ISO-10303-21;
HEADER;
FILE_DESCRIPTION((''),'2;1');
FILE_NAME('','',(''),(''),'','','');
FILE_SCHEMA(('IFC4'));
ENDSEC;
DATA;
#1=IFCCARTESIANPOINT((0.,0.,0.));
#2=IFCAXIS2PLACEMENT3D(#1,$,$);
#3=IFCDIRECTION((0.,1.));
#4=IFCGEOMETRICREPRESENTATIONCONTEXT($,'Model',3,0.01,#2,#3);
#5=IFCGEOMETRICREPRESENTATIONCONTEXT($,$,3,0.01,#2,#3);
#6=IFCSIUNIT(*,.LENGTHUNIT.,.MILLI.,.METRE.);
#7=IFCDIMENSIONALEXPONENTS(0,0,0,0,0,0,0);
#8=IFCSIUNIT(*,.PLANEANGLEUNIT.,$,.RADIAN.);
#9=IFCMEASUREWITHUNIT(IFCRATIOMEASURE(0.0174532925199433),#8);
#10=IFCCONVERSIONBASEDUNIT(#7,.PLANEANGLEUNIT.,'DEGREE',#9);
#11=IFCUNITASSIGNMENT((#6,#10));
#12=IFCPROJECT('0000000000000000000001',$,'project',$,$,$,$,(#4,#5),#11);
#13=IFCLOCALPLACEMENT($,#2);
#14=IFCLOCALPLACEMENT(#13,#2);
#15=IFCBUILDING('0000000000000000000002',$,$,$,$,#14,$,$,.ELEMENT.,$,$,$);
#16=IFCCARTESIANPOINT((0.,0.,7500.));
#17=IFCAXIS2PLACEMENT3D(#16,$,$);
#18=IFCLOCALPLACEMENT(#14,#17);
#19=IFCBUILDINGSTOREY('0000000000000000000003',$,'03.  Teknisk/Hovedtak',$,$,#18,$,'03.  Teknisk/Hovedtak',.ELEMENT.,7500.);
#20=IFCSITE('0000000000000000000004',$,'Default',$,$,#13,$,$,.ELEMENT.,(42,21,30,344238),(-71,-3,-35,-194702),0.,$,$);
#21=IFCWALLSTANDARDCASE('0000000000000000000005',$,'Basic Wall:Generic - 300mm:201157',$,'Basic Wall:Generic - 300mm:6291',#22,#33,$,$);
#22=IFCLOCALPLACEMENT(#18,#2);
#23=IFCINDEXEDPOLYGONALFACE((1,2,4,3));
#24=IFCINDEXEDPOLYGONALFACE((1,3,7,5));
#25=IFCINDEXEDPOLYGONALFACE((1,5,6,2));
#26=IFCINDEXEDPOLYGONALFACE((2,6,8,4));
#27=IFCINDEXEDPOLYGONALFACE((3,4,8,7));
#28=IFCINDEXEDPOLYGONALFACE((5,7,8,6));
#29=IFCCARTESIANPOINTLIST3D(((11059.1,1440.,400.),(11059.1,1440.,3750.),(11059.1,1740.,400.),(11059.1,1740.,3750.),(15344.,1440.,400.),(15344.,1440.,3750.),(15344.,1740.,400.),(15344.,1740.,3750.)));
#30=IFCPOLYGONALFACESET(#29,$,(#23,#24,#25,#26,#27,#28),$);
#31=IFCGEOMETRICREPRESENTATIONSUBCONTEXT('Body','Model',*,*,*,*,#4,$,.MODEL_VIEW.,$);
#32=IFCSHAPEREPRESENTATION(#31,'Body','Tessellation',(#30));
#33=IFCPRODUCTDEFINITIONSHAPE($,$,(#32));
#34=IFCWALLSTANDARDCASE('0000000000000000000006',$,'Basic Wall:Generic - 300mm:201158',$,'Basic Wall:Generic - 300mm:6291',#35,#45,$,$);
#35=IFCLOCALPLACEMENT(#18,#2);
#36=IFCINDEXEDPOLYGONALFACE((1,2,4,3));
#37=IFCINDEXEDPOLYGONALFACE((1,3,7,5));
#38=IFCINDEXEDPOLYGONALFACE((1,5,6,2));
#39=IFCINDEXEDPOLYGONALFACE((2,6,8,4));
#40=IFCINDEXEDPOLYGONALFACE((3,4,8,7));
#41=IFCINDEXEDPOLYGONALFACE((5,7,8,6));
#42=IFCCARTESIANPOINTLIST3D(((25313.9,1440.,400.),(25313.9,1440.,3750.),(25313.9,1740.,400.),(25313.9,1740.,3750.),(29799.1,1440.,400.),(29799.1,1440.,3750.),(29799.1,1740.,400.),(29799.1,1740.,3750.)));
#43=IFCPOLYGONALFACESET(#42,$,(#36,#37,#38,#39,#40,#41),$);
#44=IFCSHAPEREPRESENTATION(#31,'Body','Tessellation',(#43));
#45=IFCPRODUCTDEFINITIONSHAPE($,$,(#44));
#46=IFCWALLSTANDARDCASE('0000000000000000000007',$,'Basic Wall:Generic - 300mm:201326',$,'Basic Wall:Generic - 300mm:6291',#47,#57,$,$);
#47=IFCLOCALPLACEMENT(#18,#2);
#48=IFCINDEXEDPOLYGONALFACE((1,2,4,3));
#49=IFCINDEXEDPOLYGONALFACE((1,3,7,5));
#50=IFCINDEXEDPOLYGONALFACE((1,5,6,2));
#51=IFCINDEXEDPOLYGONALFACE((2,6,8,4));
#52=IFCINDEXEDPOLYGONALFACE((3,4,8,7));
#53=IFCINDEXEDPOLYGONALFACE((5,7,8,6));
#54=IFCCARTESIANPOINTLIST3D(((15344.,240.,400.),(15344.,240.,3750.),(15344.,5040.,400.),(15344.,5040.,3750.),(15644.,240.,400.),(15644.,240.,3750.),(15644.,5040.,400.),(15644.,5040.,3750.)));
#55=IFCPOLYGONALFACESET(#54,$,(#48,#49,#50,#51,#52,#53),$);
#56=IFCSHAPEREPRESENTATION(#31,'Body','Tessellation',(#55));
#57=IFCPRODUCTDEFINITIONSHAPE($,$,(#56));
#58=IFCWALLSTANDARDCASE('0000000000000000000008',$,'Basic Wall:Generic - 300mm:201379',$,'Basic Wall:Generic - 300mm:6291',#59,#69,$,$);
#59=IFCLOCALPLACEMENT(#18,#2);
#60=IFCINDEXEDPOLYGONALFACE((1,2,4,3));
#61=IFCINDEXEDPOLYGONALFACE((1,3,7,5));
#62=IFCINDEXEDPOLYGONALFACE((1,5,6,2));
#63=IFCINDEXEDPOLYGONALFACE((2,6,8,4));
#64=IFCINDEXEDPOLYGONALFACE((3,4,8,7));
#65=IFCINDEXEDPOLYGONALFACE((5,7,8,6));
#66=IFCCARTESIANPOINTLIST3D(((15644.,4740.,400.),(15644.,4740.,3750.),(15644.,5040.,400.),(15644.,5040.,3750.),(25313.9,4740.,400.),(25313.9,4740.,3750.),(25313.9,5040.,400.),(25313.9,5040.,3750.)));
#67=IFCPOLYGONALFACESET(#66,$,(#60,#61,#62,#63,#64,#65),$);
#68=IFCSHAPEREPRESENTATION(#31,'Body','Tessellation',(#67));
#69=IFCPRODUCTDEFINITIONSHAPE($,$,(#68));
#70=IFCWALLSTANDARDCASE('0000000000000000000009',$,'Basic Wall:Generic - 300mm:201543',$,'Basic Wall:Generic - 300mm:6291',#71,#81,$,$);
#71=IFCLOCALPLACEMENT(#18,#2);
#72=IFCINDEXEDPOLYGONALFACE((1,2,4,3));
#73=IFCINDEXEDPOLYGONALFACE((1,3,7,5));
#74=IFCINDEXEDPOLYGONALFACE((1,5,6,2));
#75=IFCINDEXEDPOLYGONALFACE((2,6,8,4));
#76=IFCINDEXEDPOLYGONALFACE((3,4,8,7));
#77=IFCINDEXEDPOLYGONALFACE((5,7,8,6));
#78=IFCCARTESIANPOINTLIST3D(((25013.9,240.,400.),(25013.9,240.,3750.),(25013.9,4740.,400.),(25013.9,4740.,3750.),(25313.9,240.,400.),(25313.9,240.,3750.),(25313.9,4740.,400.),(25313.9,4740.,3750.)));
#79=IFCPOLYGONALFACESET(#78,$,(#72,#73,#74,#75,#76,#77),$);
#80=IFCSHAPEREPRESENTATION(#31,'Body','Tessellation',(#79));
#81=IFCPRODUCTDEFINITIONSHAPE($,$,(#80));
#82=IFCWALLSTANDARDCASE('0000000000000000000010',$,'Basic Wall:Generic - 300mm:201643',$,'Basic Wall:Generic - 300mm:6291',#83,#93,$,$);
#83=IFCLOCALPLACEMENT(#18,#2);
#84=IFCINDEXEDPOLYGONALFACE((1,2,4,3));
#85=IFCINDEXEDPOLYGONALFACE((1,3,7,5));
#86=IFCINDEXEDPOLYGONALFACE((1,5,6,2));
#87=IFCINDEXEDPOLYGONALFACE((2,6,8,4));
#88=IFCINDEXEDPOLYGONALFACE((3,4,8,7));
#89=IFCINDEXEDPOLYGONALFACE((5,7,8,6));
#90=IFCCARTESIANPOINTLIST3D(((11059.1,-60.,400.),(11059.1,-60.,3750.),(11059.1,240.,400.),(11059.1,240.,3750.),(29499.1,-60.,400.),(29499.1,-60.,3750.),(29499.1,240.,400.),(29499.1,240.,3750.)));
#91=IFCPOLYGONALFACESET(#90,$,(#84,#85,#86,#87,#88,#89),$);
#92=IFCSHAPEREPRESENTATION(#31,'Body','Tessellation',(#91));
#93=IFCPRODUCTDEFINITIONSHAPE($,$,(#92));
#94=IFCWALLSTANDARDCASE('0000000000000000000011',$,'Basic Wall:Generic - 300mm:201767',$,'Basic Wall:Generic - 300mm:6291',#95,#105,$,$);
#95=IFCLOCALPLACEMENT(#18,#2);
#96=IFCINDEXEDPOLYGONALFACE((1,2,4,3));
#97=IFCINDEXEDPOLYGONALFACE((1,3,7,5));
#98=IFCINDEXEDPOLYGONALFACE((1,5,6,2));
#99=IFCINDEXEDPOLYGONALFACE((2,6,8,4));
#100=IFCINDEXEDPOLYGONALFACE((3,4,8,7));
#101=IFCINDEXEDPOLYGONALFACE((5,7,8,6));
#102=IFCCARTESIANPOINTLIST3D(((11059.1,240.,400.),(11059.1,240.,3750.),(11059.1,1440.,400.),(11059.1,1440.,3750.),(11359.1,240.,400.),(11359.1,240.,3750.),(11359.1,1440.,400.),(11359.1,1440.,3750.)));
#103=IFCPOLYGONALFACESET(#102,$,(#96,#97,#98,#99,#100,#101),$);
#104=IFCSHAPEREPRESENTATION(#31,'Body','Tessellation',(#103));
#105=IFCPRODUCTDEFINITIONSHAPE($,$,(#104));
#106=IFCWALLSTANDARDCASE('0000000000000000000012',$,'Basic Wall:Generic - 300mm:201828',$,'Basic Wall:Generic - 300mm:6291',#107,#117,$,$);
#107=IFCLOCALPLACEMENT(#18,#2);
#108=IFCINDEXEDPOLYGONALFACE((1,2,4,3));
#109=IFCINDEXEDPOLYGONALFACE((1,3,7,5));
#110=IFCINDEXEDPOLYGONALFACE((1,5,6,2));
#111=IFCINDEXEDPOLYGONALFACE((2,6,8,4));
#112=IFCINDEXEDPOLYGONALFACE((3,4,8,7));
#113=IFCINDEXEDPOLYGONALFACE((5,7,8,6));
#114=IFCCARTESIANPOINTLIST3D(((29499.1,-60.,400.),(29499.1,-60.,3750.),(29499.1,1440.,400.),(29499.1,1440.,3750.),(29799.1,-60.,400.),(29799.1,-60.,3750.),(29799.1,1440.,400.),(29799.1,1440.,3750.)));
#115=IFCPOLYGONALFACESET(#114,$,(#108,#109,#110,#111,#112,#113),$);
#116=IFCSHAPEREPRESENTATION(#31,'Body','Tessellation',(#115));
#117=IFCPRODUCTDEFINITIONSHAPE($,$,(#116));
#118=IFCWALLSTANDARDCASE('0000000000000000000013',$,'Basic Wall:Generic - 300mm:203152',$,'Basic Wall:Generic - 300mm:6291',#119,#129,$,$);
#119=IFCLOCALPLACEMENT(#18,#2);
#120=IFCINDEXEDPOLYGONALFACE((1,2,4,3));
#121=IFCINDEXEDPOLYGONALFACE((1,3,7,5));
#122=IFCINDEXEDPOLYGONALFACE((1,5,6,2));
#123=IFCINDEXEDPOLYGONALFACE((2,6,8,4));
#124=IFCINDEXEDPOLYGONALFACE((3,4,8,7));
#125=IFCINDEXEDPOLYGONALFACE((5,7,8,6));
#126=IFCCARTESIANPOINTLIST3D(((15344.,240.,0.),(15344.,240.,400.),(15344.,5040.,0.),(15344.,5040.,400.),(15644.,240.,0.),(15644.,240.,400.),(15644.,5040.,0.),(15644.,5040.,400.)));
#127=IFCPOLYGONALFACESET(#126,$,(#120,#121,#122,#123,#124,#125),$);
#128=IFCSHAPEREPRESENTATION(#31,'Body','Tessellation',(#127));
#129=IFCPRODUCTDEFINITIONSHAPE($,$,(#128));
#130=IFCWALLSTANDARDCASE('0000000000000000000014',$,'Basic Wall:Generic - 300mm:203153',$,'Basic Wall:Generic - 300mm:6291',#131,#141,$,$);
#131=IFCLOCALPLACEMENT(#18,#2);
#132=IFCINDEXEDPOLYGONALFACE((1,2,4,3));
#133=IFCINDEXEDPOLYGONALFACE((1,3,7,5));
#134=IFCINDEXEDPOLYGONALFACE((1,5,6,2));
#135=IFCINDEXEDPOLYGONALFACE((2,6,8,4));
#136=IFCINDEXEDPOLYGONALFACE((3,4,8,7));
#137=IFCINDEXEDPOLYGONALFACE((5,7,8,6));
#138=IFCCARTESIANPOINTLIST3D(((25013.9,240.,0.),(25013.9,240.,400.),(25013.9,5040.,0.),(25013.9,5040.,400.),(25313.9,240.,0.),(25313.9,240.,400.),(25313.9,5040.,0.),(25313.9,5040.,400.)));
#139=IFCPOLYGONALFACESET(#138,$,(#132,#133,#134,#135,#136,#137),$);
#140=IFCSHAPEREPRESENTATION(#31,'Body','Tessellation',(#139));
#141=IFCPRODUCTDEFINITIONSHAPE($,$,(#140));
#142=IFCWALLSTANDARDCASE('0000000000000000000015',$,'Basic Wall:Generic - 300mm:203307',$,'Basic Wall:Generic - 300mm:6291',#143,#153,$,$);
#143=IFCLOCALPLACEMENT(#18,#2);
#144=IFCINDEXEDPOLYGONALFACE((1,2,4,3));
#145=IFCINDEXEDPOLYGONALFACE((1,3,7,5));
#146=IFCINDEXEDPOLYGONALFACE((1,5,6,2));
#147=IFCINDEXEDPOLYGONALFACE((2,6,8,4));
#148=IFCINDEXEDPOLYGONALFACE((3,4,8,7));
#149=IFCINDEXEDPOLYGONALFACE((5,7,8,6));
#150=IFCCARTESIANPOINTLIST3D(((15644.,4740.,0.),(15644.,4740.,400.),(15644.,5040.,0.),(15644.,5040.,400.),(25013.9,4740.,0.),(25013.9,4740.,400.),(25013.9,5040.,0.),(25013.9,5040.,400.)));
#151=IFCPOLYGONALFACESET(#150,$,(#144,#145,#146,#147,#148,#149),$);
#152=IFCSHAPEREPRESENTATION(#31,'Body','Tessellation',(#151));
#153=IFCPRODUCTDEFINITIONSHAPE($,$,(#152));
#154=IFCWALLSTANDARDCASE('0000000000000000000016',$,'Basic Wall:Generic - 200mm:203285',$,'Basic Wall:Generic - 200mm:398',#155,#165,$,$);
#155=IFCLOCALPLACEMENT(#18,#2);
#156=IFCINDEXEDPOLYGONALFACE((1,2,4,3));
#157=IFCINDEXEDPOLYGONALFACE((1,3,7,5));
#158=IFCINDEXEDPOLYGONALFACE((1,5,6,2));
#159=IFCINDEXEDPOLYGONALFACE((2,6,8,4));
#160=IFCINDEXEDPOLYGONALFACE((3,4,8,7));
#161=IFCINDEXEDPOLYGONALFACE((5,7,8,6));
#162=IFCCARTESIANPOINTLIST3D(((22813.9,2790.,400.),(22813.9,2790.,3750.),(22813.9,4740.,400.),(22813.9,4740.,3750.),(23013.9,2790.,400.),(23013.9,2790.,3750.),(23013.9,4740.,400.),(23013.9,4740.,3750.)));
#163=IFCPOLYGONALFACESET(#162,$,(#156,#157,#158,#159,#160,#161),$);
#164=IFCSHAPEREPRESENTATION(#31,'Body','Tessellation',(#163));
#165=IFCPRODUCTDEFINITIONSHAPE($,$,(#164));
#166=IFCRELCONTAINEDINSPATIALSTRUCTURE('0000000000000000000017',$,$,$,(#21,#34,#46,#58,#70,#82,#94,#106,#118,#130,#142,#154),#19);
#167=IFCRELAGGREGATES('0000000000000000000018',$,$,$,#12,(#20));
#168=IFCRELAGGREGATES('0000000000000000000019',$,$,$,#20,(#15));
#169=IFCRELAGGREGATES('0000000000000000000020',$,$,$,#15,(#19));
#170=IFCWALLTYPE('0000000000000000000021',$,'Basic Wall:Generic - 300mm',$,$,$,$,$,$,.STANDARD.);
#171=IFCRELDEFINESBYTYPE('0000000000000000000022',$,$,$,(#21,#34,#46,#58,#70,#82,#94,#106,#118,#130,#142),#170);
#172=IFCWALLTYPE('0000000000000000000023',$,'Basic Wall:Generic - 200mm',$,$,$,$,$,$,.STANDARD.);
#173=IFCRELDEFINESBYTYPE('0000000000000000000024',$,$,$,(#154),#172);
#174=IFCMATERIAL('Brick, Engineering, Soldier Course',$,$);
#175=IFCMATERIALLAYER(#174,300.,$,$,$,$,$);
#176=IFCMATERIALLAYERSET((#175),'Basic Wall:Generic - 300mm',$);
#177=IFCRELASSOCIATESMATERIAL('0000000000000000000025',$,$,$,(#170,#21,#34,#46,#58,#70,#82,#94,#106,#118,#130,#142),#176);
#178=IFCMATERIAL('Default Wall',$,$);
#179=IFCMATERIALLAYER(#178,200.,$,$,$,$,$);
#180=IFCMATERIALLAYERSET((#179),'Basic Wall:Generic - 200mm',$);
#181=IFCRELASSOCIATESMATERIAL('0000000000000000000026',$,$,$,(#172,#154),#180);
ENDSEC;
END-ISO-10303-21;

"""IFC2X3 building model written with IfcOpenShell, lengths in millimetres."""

from ifc_helpers import new_model, entity, si_unit, converted_unit, direction, frame, frame_2d, origin, place, context, subcontext, project, spatial, rectangle, extrude, clip, halfspace, material, layer, layer_set, layer_usage, type_object, element, save


model = new_model("IFC2X3")

# Units and contexts
model_context = context("Model", 3, precision=0.01, world=origin(), true_north=direction((0.0, 1.0)))
context_of_model = context(None, 3, precision=0.01, world=origin(), true_north=direction((0.0, 1.0)))
body_context = subcontext(model_context, "Body", "Model", "MODEL_VIEW")
ifc_project = project(units=[si_unit("LENGTHUNIT", "METRE", prefix="MILLI"), converted_unit("PLANEANGLEUNIT", "DEGREE", entity("IfcRatioMeasure", 0.0174532925199433), si_unit("PLANEANGLEUNIT", "RADIAN"), dimensions=[0, 0, 0, 0, 0, 0, 0])], contexts=[model_context, context_of_model])

# Site, building, storey
site_placement = place(None, origin())
site = spatial("IfcSite", under=ifc_project, at=site_placement, Name="Default", CompositionType="ELEMENT", RefLatitude=(42, 21, 30, 344238), RefLongitude=(-71, -3, -35, -194702), RefElevation=0.0)
building_placement = place(site_placement, origin())
building = spatial("IfcBuilding", under=site, at=building_placement, CompositionType="ELEMENT")
storey_placement = place(building_placement, frame((0.0, 0.0, 7500.0)))
storey = spatial("IfcBuildingStorey", under=building, at=storey_placement, Name="03.  Teknisk/Hovedtak", LongName="03.  Teknisk/Hovedtak", CompositionType="ELEMENT", Elevation=7500.0)

# Walls
ifc_material_1 = material(Name="Brick, Engineering, Soldier Course")
ifc_layer_1 = layer(ifc_material_1, 300.0)
ifc_layer_set_1 = layer_set([ifc_layer_1], Name="Basic Wall:Generic - 300mm")
wall_type_1 = type_object("IfcWallType", Name="Basic Wall:Generic - 300mm", PredefinedType="STANDARD", material=ifc_layer_set_1)
ifc_layer_usage_1 = layer_usage(ifc_layer_set_1, "AXIS2", "NEGATIVE", 150.0)
wall_1_placement = place(storey_placement, frame((15344.0, 1590.0, 400.0), z_axis=(0.0, 0.0, 1.0), x_axis=(-1.0, 0.0, 0.0)))
element("IfcWallStandardCase", 1, at=wall_1_placement, inside=storey, type_object=wall_type_1, material=ifc_layer_usage_1, Name="Basic Wall:Generic - 300mm:201157", ObjectType="Basic Wall:Generic - 300mm:6291", context=body_context, shape_type="SweptSolid", body=[
    extrude(rectangle(XDim=4284.9, YDim=300.0, at=frame_2d((2142.4, 0.0), x_axis=(-1.0, 0.0))), origin(), (0.0, 0.0, 1.0), 3350.0),
])
ifc_layer_usage_2 = layer_usage(ifc_layer_set_1, "AXIS2", "NEGATIVE", 150.0)
wall_2_placement = place(storey_placement, frame((29799.1, 1590.0, 400.0), z_axis=(0.0, 0.0, 1.0), x_axis=(-1.0, 0.0, 0.0)))
element("IfcWallStandardCase", 2, at=wall_2_placement, inside=storey, type_object=wall_type_1, material=ifc_layer_usage_2, Name="Basic Wall:Generic - 300mm:201158", ObjectType="Basic Wall:Generic - 300mm:6291", context=body_context, shape_type="SweptSolid", body=[
    extrude(rectangle(XDim=4485.2, YDim=300.0, at=frame_2d((2242.6, 0.0), x_axis=(-1.0, 0.0))), origin(), (0.0, 0.0, 1.0), 3350.0),
])
ifc_layer_usage_3 = layer_usage(ifc_layer_set_1, "AXIS2", "NEGATIVE", 150.0)
wall_3_placement = place(storey_placement, frame((15494.0, 240.0, 400.0), z_axis=(0.0, 0.0, 1.0), x_axis=(0.0, 1.0, 0.0)))
element("IfcWallStandardCase", 3, at=wall_3_placement, inside=storey, type_object=wall_type_1, material=ifc_layer_usage_3, Name="Basic Wall:Generic - 300mm:201326", ObjectType="Basic Wall:Generic - 300mm:6291", context=body_context, shape_type="SweptSolid", body=[
    extrude(rectangle(XDim=4800.0, YDim=300.0, at=frame_2d((2400.0, 0.0), x_axis=(-1.0, 0.0))), origin(), (0.0, 0.0, 1.0), 3350.0),
])
ifc_layer_usage_4 = layer_usage(ifc_layer_set_1, "AXIS2", "NEGATIVE", 150.0)
wall_4_placement = place(storey_placement, frame((15644.0, 4890.0, 400.0)))
element("IfcWallStandardCase", 4, at=wall_4_placement, inside=storey, type_object=wall_type_1, material=ifc_layer_usage_4, Name="Basic Wall:Generic - 300mm:201379", ObjectType="Basic Wall:Generic - 300mm:6291", context=body_context, shape_type="SweptSolid", body=[
    extrude(rectangle(XDim=9669.9, YDim=300.0, at=frame_2d((4834.9, 0.0), x_axis=(-1.0, 0.0))), origin(), (0.0, 0.0, 1.0), 3350.0),
])
ifc_layer_usage_5 = layer_usage(ifc_layer_set_1, "AXIS2", "NEGATIVE", 150.0)
wall_5_placement = place(storey_placement, frame((25163.9, 4740.0, 400.0), z_axis=(0.0, 0.0, 1.0), x_axis=(0.0, -1.0, 0.0)))
element("IfcWallStandardCase", 5, at=wall_5_placement, inside=storey, type_object=wall_type_1, material=ifc_layer_usage_5, Name="Basic Wall:Generic - 300mm:201543", ObjectType="Basic Wall:Generic - 300mm:6291", context=body_context, shape_type="SweptSolid", body=[
    extrude(rectangle(XDim=4500.0, YDim=300.0, at=frame_2d((2250.0, 0.0), x_axis=(-1.0, 0.0))), origin(), (0.0, 0.0, 1.0), 3350.0),
])
ifc_layer_usage_6 = layer_usage(ifc_layer_set_1, "AXIS2", "NEGATIVE", 150.0)
wall_6_placement = place(storey_placement, frame((29499.1, 90.0, 400.0), z_axis=(0.0, 0.0, 1.0), x_axis=(-1.0, 0.0, 0.0)))
element("IfcWallStandardCase", 6, at=wall_6_placement, inside=storey, type_object=wall_type_1, material=ifc_layer_usage_6, Name="Basic Wall:Generic - 300mm:201643", ObjectType="Basic Wall:Generic - 300mm:6291", context=body_context, shape_type="SweptSolid", body=[
    extrude(rectangle(XDim=18440.0, YDim=300.0, at=frame_2d((9220.0, 0.0), x_axis=(-1.0, 0.0))), origin(), (0.0, 0.0, 1.0), 3350.0),
])
ifc_layer_usage_7 = layer_usage(ifc_layer_set_1, "AXIS2", "POSITIVE", -150.0)
wall_7_placement = place(storey_placement, frame((11209.1, 1440.0, 400.0), z_axis=(0.0, 0.0, 1.0), x_axis=(0.0, -1.0, 0.0)))
element("IfcWallStandardCase", 7, at=wall_7_placement, inside=storey, type_object=wall_type_1, material=ifc_layer_usage_7, Name="Basic Wall:Generic - 300mm:201767", ObjectType="Basic Wall:Generic - 300mm:6291", context=body_context, shape_type="SweptSolid", body=[
    extrude(rectangle(XDim=1200.0, YDim=300.0, at=frame_2d((600.0, 0.0), x_axis=(-1.0, 0.0))), origin(), (0.0, 0.0, 1.0), 3350.0),
])
ifc_layer_usage_8 = layer_usage(ifc_layer_set_1, "AXIS2", "NEGATIVE", 150.0)
wall_8_placement = place(storey_placement, frame((29649.1, 1440.0, 400.0), z_axis=(0.0, 0.0, 1.0), x_axis=(0.0, -1.0, 0.0)))
element("IfcWallStandardCase", 8, at=wall_8_placement, inside=storey, type_object=wall_type_1, material=ifc_layer_usage_8, Name="Basic Wall:Generic - 300mm:201828", ObjectType="Basic Wall:Generic - 300mm:6291", context=body_context, shape_type="SweptSolid", body=[
    extrude(rectangle(XDim=1500.0, YDim=300.0, at=frame_2d((750.0, 0.0), x_axis=(-1.0, 0.0))), origin(), (0.0, 0.0, 1.0), 3350.0),
])
ifc_layer_usage_9 = layer_usage(ifc_layer_set_1, "AXIS2", "NEGATIVE", 150.0)
wall_9_placement = place(storey_placement, frame((15494.0, 240.0, 0.0), z_axis=(0.0, 0.0, 1.0), x_axis=(0.0, 1.0, 0.0)))
element("IfcWallStandardCase", 9, at=wall_9_placement, inside=storey, type_object=wall_type_1, material=ifc_layer_usage_9, Name="Basic Wall:Generic - 300mm:203152", ObjectType="Basic Wall:Generic - 300mm:6291", context=body_context, shape_type="Clipping", body=[
    clip(extrude(rectangle(XDim=4800.0, YDim=300.0, at=frame_2d((2400.0, 0.0), x_axis=(-1.0, 0.0))), origin(), (0.0, 0.0, 1.0), 400.0), halfspace(frame((0.0, 0.0, -3750.0)), True)),
])
ifc_layer_usage_10 = layer_usage(ifc_layer_set_1, "AXIS2", "NEGATIVE", 150.0)
wall_10_placement = place(storey_placement, frame((25163.9, 5040.0, 0.0), z_axis=(0.0, 0.0, 1.0), x_axis=(0.0, -1.0, 0.0)))
element("IfcWallStandardCase", 10, at=wall_10_placement, inside=storey, type_object=wall_type_1, material=ifc_layer_usage_10, Name="Basic Wall:Generic - 300mm:203153", ObjectType="Basic Wall:Generic - 300mm:6291", context=body_context, shape_type="Clipping", body=[
    clip(extrude(rectangle(XDim=4800.0, YDim=300.0, at=frame_2d((2400.0, 0.0), x_axis=(-1.0, 0.0))), origin(), (0.0, 0.0, 1.0), 400.0), halfspace(frame((0.0, 0.0, -3750.0)), True)),
])
ifc_layer_usage_11 = layer_usage(ifc_layer_set_1, "AXIS2", "NEGATIVE", 150.0)
wall_11_placement = place(storey_placement, frame((15644.0, 4890.0, 0.0)))
element("IfcWallStandardCase", 11, at=wall_11_placement, inside=storey, type_object=wall_type_1, material=ifc_layer_usage_11, Name="Basic Wall:Generic - 300mm:203307", ObjectType="Basic Wall:Generic - 300mm:6291", context=body_context, shape_type="Clipping", body=[
    clip(extrude(rectangle(XDim=9369.9, YDim=300.0, at=frame_2d((4684.9, 0.0), x_axis=(-1.0, 0.0))), origin(), (0.0, 0.0, 1.0), 400.0), halfspace(frame((0.0, 0.0, -3750.0)), True)),
])
ifc_material_2 = material(Name="Default Wall")
ifc_layer_2 = layer(ifc_material_2, 200.0)
ifc_layer_set_2 = layer_set([ifc_layer_2], Name="Basic Wall:Generic - 200mm")
ifc_layer_usage_12 = layer_usage(ifc_layer_set_2, "AXIS2", "NEGATIVE", 100.0)
wall_type_2 = type_object("IfcWallType", Name="Basic Wall:Generic - 200mm", PredefinedType="STANDARD", material=ifc_layer_set_2)
wall_12_placement = place(storey_placement, frame((22913.9, 4740.0, 400.0), z_axis=(0.0, 0.0, 1.0), x_axis=(0.0, -1.0, 0.0)))
element("IfcWallStandardCase", 12, at=wall_12_placement, inside=storey, type_object=wall_type_2, material=ifc_layer_usage_12, Name="Basic Wall:Generic - 200mm:203285", ObjectType="Basic Wall:Generic - 200mm:398", context=body_context, shape_type="SweptSolid", body=[
    extrude(rectangle(XDim=1950.0, YDim=200.0, at=frame_2d((975.0, 0.0), x_axis=(-1.0, 0.0))), origin(), (0.0, 0.0, 1.0), 3350.0),
])

save(model, "model.ifc")
